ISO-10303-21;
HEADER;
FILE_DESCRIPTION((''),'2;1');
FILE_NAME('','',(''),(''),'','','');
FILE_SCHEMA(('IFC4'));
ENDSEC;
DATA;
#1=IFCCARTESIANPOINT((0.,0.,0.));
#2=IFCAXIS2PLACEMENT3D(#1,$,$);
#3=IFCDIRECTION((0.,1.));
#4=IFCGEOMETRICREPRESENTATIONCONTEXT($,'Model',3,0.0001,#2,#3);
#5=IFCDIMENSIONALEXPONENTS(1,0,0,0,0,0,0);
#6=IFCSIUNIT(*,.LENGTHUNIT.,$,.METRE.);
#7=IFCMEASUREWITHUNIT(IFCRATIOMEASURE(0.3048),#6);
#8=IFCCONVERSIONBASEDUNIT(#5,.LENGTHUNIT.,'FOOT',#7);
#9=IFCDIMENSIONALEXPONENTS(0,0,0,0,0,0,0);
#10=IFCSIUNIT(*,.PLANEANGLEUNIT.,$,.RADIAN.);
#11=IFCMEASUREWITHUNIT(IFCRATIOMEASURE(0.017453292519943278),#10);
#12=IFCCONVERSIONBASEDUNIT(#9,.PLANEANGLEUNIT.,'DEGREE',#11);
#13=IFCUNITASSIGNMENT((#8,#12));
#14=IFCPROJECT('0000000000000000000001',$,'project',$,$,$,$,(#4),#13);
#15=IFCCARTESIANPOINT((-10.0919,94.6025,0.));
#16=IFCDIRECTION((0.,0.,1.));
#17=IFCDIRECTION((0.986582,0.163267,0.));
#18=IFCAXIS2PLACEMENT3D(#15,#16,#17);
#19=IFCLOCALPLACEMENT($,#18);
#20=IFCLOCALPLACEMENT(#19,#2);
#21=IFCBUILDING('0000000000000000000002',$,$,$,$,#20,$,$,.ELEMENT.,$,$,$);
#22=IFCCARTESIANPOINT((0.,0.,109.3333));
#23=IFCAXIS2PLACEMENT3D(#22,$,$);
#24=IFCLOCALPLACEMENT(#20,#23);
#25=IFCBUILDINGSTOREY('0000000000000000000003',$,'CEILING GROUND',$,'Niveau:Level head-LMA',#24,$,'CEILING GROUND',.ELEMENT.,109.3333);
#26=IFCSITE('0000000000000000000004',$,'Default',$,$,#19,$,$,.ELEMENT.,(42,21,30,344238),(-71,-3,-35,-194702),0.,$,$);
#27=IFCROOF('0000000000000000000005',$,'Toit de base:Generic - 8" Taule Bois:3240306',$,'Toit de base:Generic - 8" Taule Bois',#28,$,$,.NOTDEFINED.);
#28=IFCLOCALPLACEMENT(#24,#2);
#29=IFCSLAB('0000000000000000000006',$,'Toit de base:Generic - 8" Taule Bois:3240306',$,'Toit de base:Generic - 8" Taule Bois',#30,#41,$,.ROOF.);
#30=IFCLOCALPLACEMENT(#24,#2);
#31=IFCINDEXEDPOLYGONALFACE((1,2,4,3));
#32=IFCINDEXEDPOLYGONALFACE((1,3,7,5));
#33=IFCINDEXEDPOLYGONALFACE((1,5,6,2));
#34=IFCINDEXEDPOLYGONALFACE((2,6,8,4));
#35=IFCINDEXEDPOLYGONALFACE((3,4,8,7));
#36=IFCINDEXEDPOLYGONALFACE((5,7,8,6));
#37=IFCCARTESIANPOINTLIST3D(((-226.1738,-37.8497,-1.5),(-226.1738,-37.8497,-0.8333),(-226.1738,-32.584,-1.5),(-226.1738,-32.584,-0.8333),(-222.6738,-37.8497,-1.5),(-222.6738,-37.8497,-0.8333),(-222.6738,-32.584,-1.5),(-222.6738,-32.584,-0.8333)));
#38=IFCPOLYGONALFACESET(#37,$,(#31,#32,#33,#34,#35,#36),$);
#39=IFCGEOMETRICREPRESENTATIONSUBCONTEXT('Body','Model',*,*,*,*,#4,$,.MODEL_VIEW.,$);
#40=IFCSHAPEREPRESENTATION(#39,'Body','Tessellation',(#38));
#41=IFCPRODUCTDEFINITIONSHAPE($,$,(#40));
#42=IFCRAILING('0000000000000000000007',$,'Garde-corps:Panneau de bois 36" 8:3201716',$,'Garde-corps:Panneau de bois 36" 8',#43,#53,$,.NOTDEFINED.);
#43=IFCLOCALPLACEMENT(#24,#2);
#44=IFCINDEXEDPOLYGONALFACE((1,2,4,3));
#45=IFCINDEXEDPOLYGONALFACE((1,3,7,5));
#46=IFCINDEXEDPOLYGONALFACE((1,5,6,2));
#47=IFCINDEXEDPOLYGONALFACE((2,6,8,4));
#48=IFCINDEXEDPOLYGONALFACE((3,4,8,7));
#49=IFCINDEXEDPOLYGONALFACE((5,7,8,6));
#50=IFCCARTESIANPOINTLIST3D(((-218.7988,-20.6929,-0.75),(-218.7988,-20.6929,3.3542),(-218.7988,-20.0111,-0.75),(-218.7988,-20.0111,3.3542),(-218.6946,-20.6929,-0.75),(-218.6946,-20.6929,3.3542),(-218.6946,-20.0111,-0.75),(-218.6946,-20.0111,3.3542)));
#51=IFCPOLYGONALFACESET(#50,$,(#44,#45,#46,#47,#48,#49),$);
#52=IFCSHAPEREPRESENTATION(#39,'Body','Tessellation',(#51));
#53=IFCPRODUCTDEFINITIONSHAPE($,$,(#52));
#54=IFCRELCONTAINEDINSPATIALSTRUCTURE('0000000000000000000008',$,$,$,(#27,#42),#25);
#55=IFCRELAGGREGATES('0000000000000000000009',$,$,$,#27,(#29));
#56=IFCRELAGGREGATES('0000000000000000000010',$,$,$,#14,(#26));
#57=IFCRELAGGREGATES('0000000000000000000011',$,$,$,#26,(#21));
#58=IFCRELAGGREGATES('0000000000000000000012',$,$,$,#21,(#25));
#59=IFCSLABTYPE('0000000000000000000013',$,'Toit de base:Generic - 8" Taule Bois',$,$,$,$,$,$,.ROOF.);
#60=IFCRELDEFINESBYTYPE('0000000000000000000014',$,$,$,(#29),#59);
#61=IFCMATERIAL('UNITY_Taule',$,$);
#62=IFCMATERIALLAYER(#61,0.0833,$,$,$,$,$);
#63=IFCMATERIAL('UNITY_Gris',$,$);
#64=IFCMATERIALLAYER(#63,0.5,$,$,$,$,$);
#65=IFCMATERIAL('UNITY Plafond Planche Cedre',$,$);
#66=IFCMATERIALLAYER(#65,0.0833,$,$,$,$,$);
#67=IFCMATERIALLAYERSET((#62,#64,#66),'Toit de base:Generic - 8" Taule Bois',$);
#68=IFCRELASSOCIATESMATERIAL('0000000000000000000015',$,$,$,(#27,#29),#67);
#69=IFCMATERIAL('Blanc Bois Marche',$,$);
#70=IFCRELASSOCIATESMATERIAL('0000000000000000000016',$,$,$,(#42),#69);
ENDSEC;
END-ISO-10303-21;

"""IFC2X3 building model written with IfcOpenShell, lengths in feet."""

from ifc_helpers import new_model, entity, si_unit, converted_unit, direction, frame, frame_2d, origin, place, context, subcontext, project, spatial, rectangle, extrude, material, layer, layer_set, type_object, element, aggregate, save


model = new_model("IFC2X3")

# Units and contexts
model_context = context("Model", 3, precision=0.0001, world=origin(), true_north=direction((0.0, 1.0)))
body_context = subcontext(model_context, "Body", "Model", "MODEL_VIEW")
ifc_project = project(units=[converted_unit("LENGTHUNIT", "FOOT", entity("IfcRatioMeasure", 0.3048), si_unit("LENGTHUNIT", "METRE"), dimensions=[1, 0, 0, 0, 0, 0, 0]), converted_unit("PLANEANGLEUNIT", "DEGREE", entity("IfcRatioMeasure", 0.017453292519943278), si_unit("PLANEANGLEUNIT", "RADIAN"), dimensions=[0, 0, 0, 0, 0, 0, 0])], contexts=[model_context])

# Site, building, storey
site_placement = place(None, frame((-10.0919, 94.6025, 0.0), z_axis=(0.0, 0.0, 1.0), x_axis=(0.986582, 0.163267, 0.0)))
site = spatial("IfcSite", under=ifc_project, at=site_placement, Name="Default", CompositionType="ELEMENT", RefLatitude=(42, 21, 30, 344238), RefLongitude=(-71, -3, -35, -194702), RefElevation=0.0)
building_placement = place(site_placement, origin())
building = spatial("IfcBuilding", under=site, at=building_placement, CompositionType="ELEMENT")
storey_placement = place(building_placement, frame((0.0, 0.0, 109.3333)))
storey = spatial("IfcBuildingStorey", under=building, at=storey_placement, Name="CEILING GROUND", ObjectType="Niveau:Level head-LMA", LongName="CEILING GROUND", CompositionType="ELEMENT", Elevation=109.3333)

# Roof, slab
ifc_material_1 = material(Name="UNITY_Taule")
ifc_layer_1 = layer(ifc_material_1, 0.0833)
ifc_material_2 = material(Name="UNITY_Gris")
ifc_layer_2 = layer(ifc_material_2, 0.5)
ifc_material_3 = material(Name="UNITY Plafond Planche Cedre")
ifc_layer_3 = layer(ifc_material_3, 0.0833)
ifc_layer_set = layer_set([ifc_layer_1, ifc_layer_2, ifc_layer_3], Name="Toit de base:Generic - 8\" Taule Bois")
roof_placement = place(storey_placement, frame((-226.1738, -37.8497, -1.5)))
roof = element("IfcRoof", 1, at=roof_placement, inside=storey, material=ifc_layer_set, Name="Toit de base:Generic - 8\" Taule Bois:3240306", ObjectType="Toit de base:Generic - 8\" Taule Bois", ShapeType="NOTDEFINED")
slab_type = type_object("IfcSlabType", Name="Toit de base:Generic - 8\" Taule Bois", PredefinedType="ROOF")
slab_placement = place(roof_placement, origin())
slab = element("IfcSlab", 2, at=slab_placement, type_object=slab_type, material=ifc_layer_set, Name="Toit de base:Generic - 8\" Taule Bois:3240306", ObjectType="Toit de base:Generic - 8\" Taule Bois", PredefinedType="ROOF", context=body_context, shape_type="SweptSolid", body=[
    extrude(rectangle(XDim=3.5, YDim=5.2657, at=frame_2d((0.0, 0.0), x_axis=(-1.0, 0.0))), frame((1.75, 2.6329, 0.0)), (0.0, 0.0, 1.0), 0.6667),
])
aggregate(roof, [slab])

# Railing
ifc_material_4 = material(Name="Blanc Bois Marche")
railing_1_placement = place(storey_placement, origin())
element("IfcRailing", 3, at=railing_1_placement, inside=storey, material=ifc_material_4, Name="Garde-corps:Panneau de bois 36\" 8:3201716", ObjectType="Garde-corps:Panneau de bois 36\" 8", PredefinedType="NOTDEFINED", context=body_context, shape_type="SweptSolid", body=[
    extrude(rectangle(XDim=0.6818, YDim=0.1042, at=frame_2d((0.0, 0.0), x_axis=(1.0, 0.0))), frame((-218.7467, -20.352, -0.75), z_axis=(0.0, 0.0, 1.0), x_axis=(0.0, 1.0, 0.0)), (0.0, 0.0, 1.0), 4.1042),
])

save(model, "model.ifc")
